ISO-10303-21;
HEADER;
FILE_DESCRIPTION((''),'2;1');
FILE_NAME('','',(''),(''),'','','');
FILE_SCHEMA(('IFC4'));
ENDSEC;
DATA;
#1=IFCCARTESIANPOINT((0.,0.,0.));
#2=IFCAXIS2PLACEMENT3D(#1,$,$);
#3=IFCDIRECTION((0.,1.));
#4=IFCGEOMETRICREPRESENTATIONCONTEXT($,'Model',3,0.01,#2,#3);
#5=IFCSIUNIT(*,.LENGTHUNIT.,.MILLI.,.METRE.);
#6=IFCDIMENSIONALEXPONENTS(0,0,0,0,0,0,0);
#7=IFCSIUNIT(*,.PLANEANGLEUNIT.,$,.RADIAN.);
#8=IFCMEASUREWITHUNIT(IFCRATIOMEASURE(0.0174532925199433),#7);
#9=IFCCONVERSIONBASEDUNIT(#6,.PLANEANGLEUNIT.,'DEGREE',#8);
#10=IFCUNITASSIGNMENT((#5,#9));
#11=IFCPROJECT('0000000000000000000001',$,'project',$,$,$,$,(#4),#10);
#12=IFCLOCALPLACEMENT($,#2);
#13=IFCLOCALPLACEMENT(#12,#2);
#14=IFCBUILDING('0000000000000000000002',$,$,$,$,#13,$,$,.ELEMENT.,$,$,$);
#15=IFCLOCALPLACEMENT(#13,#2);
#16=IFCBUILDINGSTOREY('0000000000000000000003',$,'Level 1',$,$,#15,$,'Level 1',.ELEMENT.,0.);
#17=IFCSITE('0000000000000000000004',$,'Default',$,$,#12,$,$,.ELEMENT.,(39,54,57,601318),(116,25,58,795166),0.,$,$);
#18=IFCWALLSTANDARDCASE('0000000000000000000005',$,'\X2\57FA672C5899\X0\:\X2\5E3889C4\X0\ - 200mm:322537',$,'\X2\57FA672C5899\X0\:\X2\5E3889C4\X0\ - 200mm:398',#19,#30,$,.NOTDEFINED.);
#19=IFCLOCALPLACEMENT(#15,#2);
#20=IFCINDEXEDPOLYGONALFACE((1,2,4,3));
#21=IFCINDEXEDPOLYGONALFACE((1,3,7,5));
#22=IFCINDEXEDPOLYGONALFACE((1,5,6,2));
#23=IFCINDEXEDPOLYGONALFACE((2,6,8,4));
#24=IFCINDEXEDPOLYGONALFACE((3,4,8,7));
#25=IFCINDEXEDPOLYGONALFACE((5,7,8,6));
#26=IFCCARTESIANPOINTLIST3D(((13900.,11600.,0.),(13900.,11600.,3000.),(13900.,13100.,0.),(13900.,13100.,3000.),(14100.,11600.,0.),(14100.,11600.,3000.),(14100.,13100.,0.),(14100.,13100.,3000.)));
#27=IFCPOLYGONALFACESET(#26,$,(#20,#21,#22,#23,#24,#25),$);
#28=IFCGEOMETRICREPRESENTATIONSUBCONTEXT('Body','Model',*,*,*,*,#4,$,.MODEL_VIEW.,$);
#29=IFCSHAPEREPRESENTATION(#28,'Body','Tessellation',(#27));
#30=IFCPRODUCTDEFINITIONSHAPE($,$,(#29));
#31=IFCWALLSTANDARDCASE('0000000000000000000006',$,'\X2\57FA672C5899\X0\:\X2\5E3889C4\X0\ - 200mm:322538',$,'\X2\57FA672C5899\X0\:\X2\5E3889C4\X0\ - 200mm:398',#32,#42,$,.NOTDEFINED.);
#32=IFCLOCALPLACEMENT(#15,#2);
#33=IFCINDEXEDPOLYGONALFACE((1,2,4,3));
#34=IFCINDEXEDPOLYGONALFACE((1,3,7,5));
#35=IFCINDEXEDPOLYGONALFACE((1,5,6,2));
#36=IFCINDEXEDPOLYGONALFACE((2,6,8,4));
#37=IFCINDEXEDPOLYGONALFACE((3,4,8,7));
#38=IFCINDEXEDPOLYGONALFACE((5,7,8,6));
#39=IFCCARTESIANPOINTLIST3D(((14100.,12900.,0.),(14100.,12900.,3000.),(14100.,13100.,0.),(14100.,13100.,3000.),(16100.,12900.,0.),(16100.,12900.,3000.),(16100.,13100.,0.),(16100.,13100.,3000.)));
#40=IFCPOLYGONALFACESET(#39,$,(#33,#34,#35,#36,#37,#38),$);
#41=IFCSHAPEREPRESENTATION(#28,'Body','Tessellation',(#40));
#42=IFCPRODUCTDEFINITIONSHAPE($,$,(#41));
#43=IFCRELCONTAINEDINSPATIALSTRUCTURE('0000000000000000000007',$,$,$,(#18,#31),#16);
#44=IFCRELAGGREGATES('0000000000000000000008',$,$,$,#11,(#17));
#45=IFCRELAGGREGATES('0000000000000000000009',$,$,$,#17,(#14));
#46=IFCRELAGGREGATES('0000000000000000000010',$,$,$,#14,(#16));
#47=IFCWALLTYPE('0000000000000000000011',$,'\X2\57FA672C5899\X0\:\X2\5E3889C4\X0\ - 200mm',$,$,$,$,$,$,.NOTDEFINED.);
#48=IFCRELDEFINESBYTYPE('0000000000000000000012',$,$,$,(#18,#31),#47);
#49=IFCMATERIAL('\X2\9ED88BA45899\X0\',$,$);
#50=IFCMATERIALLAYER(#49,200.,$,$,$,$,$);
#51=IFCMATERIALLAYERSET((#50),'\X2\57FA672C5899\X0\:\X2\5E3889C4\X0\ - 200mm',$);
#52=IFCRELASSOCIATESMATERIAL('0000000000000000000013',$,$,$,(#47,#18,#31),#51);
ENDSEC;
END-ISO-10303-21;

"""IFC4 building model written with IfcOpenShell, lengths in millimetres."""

from ifc_helpers import new_model, entity, si_unit, converted_unit, direction, frame, frame_2d, origin, place, context, subcontext, project, spatial, rectangle, extrude, material, layer, layer_set, layer_usage, type_object, element, save


model = new_model("IFC4")

# Units and contexts
model_context = context("Model", 3, precision=0.01, world=origin(), true_north=direction((0.0, 1.0)))
body_context = subcontext(model_context, "Body", "Model", "MODEL_VIEW")
ifc_project = project(units=[si_unit("LENGTHUNIT", "METRE", prefix="MILLI"), converted_unit("PLANEANGLEUNIT", "DEGREE", entity("IfcRatioMeasure", 0.0174532925199433), si_unit("PLANEANGLEUNIT", "RADIAN"), dimensions=[0, 0, 0, 0, 0, 0, 0])], contexts=[model_context])

# Site, building, storey
site_placement = place(None, origin())
site = spatial("IfcSite", under=ifc_project, at=site_placement, Name="Default", CompositionType="ELEMENT", RefLatitude=(39, 54, 57, 601318), RefLongitude=(116, 25, 58, 795166), RefElevation=0.0)
building_placement = place(site_placement, origin())
building = spatial("IfcBuilding", under=site, at=building_placement, CompositionType="ELEMENT")
storey_placement = place(building_placement, origin())
storey = spatial("IfcBuildingStorey", under=building, at=storey_placement, Name="Level 1", LongName="Level 1", CompositionType="ELEMENT", Elevation=0.0)

# Shared definitions
ifc_material_1 = material(Name="默认墙")
ifc_layer_1 = layer(ifc_material_1, 200.0)
ifc_layer_set_1 = layer_set([ifc_layer_1], Name="基本墙:常规 - 200mm")
wall_type = type_object("IfcWallType", Name="基本墙:常规 - 200mm", PredefinedType="NOTDEFINED", material=ifc_layer_set_1)

# Walls
ifc_layer_usage_1 = layer_usage(ifc_layer_set_1, "AXIS2", "NEGATIVE", 100.0)
wall_1_placement = place(storey_placement, frame((14000.0, 11600.0, 0.0), z_axis=(0.0, 0.0, 1.0), x_axis=(0.0, 1.0, 0.0)))
element("IfcWallStandardCase", 1, at=wall_1_placement, inside=storey, type_object=wall_type, material=ifc_layer_usage_1, Name="基本墙:常规 - 200mm:322537", ObjectType="基本墙:常规 - 200mm:398", PredefinedType="NOTDEFINED", context=body_context, shape_type="SweptSolid", body=[
    extrude(rectangle(XDim=1500.0, YDim=200.0, at=frame_2d((750.0, 0.0), x_axis=(-1.0, 0.0))), origin(), (0.0, 0.0, 1.0), 3000.0),
])
ifc_layer_usage_2 = layer_usage(ifc_layer_set_1, "AXIS2", "NEGATIVE", 100.0)
wall_2_placement = place(storey_placement, frame((14100.0, 13000.0, 0.0)))
element("IfcWallStandardCase", 2, at=wall_2_placement, inside=storey, type_object=wall_type, material=ifc_layer_usage_2, Name="基本墙:常规 - 200mm:322538", ObjectType="基本墙:常规 - 200mm:398", PredefinedType="NOTDEFINED", context=body_context, shape_type="SweptSolid", body=[
    extrude(rectangle(XDim=2000.0, YDim=200.0, at=frame_2d((1000.0, 0.0), x_axis=(-1.0, 0.0))), origin(), (0.0, 0.0, 1.0), 3000.0),
])

save(model, "model.ifc")
